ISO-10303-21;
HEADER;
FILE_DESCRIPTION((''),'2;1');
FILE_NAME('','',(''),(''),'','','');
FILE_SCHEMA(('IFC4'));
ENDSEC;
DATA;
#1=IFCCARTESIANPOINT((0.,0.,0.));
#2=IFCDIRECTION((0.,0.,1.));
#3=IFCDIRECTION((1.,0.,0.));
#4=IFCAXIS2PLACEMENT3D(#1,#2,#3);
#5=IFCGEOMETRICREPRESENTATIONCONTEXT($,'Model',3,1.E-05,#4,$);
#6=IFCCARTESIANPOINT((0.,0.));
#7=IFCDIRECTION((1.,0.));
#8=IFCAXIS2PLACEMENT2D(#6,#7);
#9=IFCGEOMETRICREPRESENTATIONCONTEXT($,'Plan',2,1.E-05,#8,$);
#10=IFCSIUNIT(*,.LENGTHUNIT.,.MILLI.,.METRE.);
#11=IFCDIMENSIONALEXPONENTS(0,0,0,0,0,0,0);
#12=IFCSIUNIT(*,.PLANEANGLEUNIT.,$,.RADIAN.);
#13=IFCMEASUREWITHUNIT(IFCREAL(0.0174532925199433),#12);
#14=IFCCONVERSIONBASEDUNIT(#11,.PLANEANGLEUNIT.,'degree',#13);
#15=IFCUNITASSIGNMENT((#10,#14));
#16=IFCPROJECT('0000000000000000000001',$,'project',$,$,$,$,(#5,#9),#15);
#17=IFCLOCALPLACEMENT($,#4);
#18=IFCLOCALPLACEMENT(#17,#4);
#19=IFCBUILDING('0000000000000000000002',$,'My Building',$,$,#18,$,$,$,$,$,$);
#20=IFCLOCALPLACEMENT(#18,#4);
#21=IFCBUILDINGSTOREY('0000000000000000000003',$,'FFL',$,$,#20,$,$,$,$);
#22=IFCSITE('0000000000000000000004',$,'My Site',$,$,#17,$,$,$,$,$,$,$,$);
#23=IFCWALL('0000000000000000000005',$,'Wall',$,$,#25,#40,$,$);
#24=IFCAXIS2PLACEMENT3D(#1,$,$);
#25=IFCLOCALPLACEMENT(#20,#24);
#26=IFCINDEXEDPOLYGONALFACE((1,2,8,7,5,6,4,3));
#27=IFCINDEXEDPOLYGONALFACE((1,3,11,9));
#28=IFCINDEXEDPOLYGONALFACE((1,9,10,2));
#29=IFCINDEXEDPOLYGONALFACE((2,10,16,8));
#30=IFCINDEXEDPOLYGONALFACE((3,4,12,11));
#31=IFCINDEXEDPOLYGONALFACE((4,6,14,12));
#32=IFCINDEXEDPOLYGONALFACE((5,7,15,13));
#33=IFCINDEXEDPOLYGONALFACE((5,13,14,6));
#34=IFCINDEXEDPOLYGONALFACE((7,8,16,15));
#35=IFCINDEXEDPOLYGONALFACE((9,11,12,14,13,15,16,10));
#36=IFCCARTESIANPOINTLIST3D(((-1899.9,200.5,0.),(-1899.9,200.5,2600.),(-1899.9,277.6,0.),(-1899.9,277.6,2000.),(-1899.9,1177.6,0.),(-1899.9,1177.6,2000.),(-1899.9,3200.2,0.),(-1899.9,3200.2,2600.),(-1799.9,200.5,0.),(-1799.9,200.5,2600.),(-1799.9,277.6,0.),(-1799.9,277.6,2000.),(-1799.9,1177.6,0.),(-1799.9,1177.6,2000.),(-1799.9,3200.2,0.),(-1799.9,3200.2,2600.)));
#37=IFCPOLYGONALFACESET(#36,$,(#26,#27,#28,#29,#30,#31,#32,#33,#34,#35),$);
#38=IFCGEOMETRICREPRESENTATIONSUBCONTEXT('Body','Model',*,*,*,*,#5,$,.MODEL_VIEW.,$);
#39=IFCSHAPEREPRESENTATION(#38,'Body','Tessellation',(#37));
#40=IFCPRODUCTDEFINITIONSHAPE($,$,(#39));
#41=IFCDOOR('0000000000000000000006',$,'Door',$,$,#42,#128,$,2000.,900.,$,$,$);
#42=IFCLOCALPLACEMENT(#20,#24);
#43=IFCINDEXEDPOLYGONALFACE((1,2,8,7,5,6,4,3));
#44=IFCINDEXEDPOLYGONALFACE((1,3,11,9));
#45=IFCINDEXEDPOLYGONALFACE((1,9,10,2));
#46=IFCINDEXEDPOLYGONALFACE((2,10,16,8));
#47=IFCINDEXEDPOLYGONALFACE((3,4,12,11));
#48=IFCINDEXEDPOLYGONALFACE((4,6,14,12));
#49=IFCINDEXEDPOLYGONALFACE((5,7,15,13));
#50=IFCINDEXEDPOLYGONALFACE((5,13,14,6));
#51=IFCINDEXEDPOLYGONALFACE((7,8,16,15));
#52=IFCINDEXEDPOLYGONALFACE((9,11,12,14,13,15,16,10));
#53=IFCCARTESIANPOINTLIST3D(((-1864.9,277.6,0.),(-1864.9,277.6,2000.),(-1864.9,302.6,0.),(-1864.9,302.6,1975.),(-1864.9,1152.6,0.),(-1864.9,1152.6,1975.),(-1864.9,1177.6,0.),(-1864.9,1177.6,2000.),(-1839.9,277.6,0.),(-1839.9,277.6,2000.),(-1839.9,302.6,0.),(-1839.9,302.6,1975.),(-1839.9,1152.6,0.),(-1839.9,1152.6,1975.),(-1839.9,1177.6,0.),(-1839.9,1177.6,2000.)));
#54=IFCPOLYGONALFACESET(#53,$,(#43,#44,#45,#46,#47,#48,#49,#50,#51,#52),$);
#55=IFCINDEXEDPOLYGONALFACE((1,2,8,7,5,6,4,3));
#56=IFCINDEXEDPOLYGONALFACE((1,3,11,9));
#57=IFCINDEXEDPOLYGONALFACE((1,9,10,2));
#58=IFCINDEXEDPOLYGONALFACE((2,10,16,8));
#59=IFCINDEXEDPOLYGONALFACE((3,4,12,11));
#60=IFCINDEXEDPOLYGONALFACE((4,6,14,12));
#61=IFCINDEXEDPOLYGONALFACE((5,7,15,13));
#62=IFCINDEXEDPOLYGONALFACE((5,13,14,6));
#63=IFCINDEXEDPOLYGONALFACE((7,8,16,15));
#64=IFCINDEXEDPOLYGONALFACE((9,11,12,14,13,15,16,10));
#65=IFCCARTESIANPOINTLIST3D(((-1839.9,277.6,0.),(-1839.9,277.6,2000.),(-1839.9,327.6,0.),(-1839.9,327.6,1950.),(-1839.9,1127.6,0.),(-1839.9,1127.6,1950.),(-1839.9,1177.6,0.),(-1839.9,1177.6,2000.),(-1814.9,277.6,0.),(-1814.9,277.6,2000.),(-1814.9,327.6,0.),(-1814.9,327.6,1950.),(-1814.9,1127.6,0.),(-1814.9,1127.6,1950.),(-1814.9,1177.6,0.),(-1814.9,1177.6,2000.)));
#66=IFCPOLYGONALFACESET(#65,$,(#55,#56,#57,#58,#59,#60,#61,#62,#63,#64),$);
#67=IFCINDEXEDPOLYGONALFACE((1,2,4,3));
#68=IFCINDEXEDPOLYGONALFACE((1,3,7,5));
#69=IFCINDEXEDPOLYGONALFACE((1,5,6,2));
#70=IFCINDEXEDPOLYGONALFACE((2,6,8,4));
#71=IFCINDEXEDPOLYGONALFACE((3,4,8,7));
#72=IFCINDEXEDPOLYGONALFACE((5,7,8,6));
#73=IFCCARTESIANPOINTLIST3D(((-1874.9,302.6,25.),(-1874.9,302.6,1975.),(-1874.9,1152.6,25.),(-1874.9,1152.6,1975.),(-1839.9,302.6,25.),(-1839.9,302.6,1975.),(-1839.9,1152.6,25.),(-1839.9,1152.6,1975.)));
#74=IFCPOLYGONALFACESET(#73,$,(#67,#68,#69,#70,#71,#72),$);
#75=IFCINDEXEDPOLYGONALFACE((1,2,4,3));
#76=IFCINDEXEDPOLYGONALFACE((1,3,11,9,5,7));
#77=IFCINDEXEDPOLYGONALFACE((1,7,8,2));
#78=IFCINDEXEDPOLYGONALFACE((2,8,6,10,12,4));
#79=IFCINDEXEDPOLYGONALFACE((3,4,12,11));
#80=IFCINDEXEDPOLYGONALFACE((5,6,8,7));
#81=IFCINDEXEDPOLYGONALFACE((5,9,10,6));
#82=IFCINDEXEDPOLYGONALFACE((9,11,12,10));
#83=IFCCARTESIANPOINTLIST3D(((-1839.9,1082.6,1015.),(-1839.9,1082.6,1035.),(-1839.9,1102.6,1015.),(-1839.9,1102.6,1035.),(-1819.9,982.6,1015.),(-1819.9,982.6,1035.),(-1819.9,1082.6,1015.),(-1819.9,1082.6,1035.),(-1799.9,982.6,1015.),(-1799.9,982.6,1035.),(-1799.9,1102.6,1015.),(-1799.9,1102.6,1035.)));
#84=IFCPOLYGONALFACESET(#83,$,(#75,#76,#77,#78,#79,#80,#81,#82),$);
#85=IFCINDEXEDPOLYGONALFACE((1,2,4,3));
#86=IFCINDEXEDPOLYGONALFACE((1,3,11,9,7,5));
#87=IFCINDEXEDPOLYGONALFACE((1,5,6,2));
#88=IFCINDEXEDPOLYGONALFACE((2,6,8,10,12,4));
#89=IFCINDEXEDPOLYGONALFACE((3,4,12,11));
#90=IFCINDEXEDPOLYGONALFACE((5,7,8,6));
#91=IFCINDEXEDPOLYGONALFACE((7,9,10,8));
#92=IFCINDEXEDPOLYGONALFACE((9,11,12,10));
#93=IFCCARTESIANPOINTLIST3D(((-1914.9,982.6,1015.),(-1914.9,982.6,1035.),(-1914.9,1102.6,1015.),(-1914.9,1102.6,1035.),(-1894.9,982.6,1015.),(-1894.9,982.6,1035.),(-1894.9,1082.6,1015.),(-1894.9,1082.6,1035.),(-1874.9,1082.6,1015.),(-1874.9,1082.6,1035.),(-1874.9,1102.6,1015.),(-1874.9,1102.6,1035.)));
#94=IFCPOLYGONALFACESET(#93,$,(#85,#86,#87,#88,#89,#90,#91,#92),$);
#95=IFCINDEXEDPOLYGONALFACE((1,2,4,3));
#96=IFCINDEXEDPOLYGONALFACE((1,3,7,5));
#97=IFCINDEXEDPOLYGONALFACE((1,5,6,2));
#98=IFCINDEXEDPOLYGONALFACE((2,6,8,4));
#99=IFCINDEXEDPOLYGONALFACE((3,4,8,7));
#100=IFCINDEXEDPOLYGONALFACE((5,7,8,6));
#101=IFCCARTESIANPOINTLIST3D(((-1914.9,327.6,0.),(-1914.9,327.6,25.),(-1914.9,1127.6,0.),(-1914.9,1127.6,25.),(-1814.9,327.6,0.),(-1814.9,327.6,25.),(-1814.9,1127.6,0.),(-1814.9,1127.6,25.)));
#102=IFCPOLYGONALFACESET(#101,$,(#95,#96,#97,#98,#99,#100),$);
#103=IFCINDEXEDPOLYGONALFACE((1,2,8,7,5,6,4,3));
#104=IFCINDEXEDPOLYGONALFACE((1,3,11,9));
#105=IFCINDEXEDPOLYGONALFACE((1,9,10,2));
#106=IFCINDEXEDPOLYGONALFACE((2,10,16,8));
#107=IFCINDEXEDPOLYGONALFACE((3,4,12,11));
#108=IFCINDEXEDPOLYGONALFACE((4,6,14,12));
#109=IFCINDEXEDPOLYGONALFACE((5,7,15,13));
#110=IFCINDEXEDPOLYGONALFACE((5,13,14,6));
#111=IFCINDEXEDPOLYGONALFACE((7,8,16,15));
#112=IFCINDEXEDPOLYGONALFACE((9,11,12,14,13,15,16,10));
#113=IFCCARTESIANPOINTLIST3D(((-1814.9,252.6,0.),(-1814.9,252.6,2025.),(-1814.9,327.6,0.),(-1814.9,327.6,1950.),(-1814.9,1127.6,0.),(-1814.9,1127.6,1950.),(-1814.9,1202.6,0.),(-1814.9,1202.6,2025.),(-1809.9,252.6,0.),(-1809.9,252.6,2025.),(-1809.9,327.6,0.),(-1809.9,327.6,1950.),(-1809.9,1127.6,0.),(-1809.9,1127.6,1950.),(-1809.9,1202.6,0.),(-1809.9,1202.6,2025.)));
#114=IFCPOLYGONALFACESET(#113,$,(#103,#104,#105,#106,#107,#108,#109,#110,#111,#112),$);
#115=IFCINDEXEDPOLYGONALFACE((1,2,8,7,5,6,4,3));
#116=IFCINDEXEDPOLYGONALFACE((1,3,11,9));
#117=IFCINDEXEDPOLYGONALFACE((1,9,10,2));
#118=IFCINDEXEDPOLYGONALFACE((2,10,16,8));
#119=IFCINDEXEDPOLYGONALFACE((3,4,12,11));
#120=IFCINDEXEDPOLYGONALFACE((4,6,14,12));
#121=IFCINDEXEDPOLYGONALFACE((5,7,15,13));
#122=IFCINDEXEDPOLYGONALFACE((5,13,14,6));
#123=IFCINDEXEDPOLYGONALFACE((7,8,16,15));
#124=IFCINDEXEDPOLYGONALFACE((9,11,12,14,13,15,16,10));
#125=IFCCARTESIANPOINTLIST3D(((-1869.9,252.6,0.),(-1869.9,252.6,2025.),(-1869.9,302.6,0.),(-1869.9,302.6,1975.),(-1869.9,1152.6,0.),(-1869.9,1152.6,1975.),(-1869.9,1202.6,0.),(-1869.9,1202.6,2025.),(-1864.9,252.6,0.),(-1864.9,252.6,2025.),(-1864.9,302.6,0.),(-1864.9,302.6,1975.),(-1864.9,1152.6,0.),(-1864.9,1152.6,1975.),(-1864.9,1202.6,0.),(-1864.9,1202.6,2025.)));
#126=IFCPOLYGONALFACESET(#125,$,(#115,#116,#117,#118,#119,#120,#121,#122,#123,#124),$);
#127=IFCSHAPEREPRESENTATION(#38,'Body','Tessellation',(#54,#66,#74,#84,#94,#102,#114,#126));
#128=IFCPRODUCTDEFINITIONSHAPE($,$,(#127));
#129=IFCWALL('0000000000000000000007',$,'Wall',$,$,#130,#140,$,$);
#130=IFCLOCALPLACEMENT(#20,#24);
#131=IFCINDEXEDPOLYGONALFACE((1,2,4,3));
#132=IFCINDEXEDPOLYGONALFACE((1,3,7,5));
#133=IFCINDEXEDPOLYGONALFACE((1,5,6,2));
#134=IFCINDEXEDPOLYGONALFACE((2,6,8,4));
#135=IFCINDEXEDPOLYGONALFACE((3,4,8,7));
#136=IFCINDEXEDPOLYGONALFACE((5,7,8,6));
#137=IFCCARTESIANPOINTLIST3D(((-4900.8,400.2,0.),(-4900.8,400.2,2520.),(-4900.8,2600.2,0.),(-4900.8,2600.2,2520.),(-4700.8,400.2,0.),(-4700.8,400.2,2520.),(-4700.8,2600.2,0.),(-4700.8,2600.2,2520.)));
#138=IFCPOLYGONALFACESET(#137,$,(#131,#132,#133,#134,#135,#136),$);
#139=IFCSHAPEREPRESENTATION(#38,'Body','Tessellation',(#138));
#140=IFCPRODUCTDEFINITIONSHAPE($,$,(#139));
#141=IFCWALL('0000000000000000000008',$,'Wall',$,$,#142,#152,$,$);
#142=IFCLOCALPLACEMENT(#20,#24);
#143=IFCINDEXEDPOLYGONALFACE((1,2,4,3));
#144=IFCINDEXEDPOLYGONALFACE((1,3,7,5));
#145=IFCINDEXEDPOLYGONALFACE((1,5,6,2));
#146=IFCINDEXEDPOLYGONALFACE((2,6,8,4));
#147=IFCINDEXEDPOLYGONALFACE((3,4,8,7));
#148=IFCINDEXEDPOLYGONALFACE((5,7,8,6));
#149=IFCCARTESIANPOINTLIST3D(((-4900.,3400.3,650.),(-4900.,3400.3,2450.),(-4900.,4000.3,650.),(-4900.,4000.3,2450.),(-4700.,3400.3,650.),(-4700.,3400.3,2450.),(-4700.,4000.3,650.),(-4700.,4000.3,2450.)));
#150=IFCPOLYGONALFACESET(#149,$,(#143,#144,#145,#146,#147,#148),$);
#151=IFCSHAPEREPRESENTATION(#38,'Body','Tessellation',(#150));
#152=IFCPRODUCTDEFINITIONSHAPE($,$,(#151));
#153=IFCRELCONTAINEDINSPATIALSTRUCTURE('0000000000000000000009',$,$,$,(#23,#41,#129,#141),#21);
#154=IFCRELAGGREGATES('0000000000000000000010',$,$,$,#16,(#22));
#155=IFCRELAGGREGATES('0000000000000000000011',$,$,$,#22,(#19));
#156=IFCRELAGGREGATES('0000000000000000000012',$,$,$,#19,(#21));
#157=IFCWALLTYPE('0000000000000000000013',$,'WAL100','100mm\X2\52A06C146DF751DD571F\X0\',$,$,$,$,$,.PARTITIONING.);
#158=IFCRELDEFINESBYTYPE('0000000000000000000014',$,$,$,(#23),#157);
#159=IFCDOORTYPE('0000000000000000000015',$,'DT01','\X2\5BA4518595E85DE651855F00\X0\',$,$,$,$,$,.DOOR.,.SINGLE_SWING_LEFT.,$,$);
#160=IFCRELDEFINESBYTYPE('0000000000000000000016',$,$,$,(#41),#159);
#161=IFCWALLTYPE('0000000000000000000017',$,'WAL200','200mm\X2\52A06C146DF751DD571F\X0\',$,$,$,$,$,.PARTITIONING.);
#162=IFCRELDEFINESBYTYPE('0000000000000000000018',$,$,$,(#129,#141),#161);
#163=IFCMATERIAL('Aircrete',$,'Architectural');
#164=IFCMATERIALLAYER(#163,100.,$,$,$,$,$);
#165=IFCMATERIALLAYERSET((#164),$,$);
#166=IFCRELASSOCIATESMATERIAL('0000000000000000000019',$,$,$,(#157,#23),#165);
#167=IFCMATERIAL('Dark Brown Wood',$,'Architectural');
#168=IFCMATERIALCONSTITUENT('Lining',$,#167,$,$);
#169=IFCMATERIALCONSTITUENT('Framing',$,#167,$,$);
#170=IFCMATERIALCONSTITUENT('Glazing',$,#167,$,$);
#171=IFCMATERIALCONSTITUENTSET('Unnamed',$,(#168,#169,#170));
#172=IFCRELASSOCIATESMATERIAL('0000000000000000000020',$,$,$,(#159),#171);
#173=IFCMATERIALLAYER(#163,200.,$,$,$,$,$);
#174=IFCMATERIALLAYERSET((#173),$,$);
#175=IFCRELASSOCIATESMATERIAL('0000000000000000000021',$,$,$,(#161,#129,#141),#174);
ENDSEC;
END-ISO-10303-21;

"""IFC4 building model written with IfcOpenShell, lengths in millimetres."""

from ifc_helpers import new_model, entity, si_unit, converted_unit, frame, origin_with_axes, origin_2d_with_axis, place, context, subcontext, project, spatial, line, indexed_curve, outline, extrude, shape, source, transform, mapped, material, layer, layer_set, layer_usage, constituent, constituent_set, type_object, type_shapes, element, fill, save


model = new_model("IFC4")

# Units and contexts
model_context = context("Model", 3, precision=1e-05, world=origin_with_axes())
plan_context = context("Plan", 2, precision=1e-05, world=origin_2d_with_axis())
body_context_1 = subcontext(model_context, "Body", "Model", "MODEL_VIEW")
body_context_2 = subcontext(plan_context, "Body", "Plan", "PLAN_VIEW")
ifc_project = project(units=[si_unit("LENGTHUNIT", "METRE", prefix="MILLI"), converted_unit("PLANEANGLEUNIT", "degree", entity("IfcReal", 0.0174532925199433), si_unit("PLANEANGLEUNIT", "RADIAN"), dimensions=[0, 0, 0, 0, 0, 0, 0])], contexts=[model_context, plan_context])

# Site, building, storey
site_placement = place(None, origin_with_axes())
site = spatial("IfcSite", under=ifc_project, at=site_placement, Name="My Site")
building_placement = place(site_placement, origin_with_axes())
building = spatial("IfcBuilding", under=site, at=building_placement, Name="My Building")
storey_placement = place(building_placement, origin_with_axes())
storey = spatial("IfcBuildingStorey", under=building, at=storey_placement, Name="FFL")

# Shared definitions
ifc_material_1 = material(Name="Aircrete", Category="Architectural")

# Wall, opening, door
ifc_layer_1 = layer(ifc_material_1, 100.0)
ifc_layer_set_1 = layer_set([ifc_layer_1])
ifc_layer_usage_1 = layer_usage(ifc_layer_set_1, "AXIS2", "POSITIVE", 0.0)
wall_type_1 = type_object("IfcWallType", Name="WAL100", Description="100mm加气混凝土", PredefinedType="PARTITIONING", material=ifc_layer_set_1)
wall_1_placement = place(storey_placement, frame((-1899.9, 3200.2, 0.0), z_axis=(0.0, 0.0, 1.0), x_axis=(0.0, -1.0, 0.0)))
wall_1 = element("IfcWall", 1, at=wall_1_placement, inside=storey, type_object=wall_type_1, material=ifc_layer_usage_1, Name="Wall", context=body_context_1, shape_type="SweptSolid", body=[
    extrude(outline(indexed_curve([(0.0, 0.0), (0.0, 100.0), (2999.7, 100.0), (2999.7, 0.0)], segments=[line(1, 2, 3, 4, 1)])), origin_with_axes(), (0.0, 0.0, 1.0), 2600.0),
])
shared_shape_1 = source(origin_with_axes(), body_context_1, "Body", "SweptSolid", [
    extrude(outline(indexed_curve([(0.0, 0.0), (900.0, 0.0), (900.0, 2000.0), (0.0, 2000.0)], segments=[line(1, 2, 3, 4, 1)])), frame((0.0, -600.0, 0.0), z_axis=(0.0, -1.0, 0.0), x_axis=(1.0, 0.0, 0.0)), (0.0, 0.0, -1.0), 1200.0),
])
opening_1_placement = place(wall_1_placement, frame((2922.6, 85.0, 0.0), z_axis=(0.0, 0.0, 1.0), x_axis=(-1.0, 0.0, 0.0)))
opening_1 = element("IfcOpeningElement", 2, at=opening_1_placement, cuts=wall_1, PredefinedType="OPENING", context=body_context_1, shape_type="MappedRepresentation", body=[
    mapped(shared_shape_1, transform((0.0, 0.0, 0.0), x_axis=(1.0, 0.0, 0.0), y_axis=(0.0, 1.0, 0.0), z_axis=(0.0, 0.0, 1.0), scale=1.0)),
])
ifc_material_2 = material(Name="Dark Brown Wood", Category="Architectural")
ifc_constituent_1 = constituent(ifc_material_2, Name="Lining")
ifc_constituent_2 = constituent(ifc_material_2, Name="Framing")
ifc_constituent_3 = constituent(ifc_material_2, Name="Glazing")
ifc_constituent_set_1 = constituent_set(constituents=[ifc_constituent_1, ifc_constituent_2, ifc_constituent_3], Name="Unnamed")
door_type = type_object("IfcDoorType", Name="DT01", Description="室内门左内开", OperationType="SINGLE_SWING_LEFT", PredefinedType="DOOR", material=ifc_constituent_set_1)
shared_shape_2 = source(origin_with_axes(), body_context_1, "Body", "SweptSolid", [
    extrude(outline(indexed_curve([(0.0, 0.0), (0.0, 2000.0), (900.0, 2000.0), (900.0, 0.0), (875.0, 0.0), (875.0, 1975.0), (25.0, 1975.0), (25.0, 0.0)], segments=[line(1, 2, 3, 4, 5, 6, 7, 8, 1)])), frame((0.0, 25.0, 0.0), z_axis=(0.0, -1.0, 0.0), x_axis=(1.0, 0.0, 0.0)), (0.0, 0.0, -1.0), 25.0),
    extrude(outline(indexed_curve([(0.0, 0.0), (0.0, 2000.0), (900.0, 2000.0), (900.0, 0.0), (850.0, 0.0), (850.0, 1950.0), (50.0, 1950.0), (50.0, 0.0)], segments=[line(1, 2, 3, 4, 5, 6, 7, 8, 1)])), frame((0.0, 0.0, 0.0), z_axis=(0.0, -1.0, 0.0), x_axis=(1.0, 0.0, 0.0)), (0.0, 0.0, -1.0), 25.0),
    extrude(outline(indexed_curve([(0.0, 0.0), (850.0, 0.0), (850.0, 35.0), (0.0, 35.0)], segments=[line(1, 2, 3, 4, 1)])), frame((25.0, 25.0, 25.0), z_axis=(0.0, 0.0, 1.0), x_axis=(1.0, 0.0, 0.0)), (0.0, 0.0, 1.0), 1950.0),
    extrude(outline(indexed_curve([(0.0, 0.0), (0.0, -40.0), (-120.0, -40.0), (-120.0, -20.0), (-20.0, -20.0), (-20.0, 0.0)], segments=[line(1, 2, 3, 4, 5, 6, 1)])), frame((825.0, 25.0, 1015.0), z_axis=(0.0, 0.0, 1.0), x_axis=(1.0, 0.0, 0.0)), (0.0, 0.0, 1.0), 20.0),
    extrude(outline(indexed_curve([(0.0, 0.0), (0.0, 40.0), (-120.0, 40.0), (-120.0, 20.0), (-20.0, 20.0), (-20.0, 0.0)], segments=[line(1, 2, 3, 4, 5, 6, 1)])), frame((825.0, 60.0, 1015.0), z_axis=(0.0, 0.0, 1.0), x_axis=(1.0, 0.0, 0.0)), (0.0, 0.0, 1.0), 20.0),
    extrude(outline(indexed_curve([(0.0, 0.0), (800.0, 0.0), (800.0, 100.0), (0.0, 100.0)], segments=[line(1, 2, 3, 4, 1)])), frame((50.0, 0.0, 0.0), z_axis=(0.0, 0.0, 1.0), x_axis=(1.0, 0.0, 0.0)), (0.0, 0.0, 1.0), 25.0),
    extrude(outline(indexed_curve([(0.0, 0.0), (0.0, 2025.0), (950.0, 2025.0), (950.0, 0.0), (875.0, 0.0), (875.0, 1950.0), (75.0, 1950.0), (75.0, 0.0)], segments=[line(1, 2, 3, 4, 5, 6, 7, 8, 1)])), frame((-25.0, -5.0, 0.0), z_axis=(0.0, -1.0, 0.0), x_axis=(1.0, 0.0, 0.0)), (0.0, 0.0, -1.0), 5.0),
    extrude(outline(indexed_curve([(0.0, 0.0), (0.0, 2025.0), (950.0, 2025.0), (950.0, 0.0), (900.0, 0.0), (900.0, 1975.0), (50.0, 1975.0), (50.0, 0.0)], segments=[line(1, 2, 3, 4, 5, 6, 7, 8, 1)])), frame((-25.0, 50.0, 0.0), z_axis=(0.0, -1.0, 0.0), x_axis=(1.0, 0.0, 0.0)), (0.0, 0.0, -1.0), 5.0),
])
shared_shape_3 = source(origin_with_axes(), body_context_2, "Body", "Curve2D", [
    entity("IfcIndexedPolyCurve", entity("IfcCartesianPointList2D", [[0.0, 0.0], [0.0, 50.0], [25.0, 50.0], [25.0, 25.0], [50.0, 25.0], [50.0, 0.0]]), [entity("IfcLineIndex", [1, 2, 3, 4, 5, 6, 1])]),
    entity("IfcIndexedPolyCurve", entity("IfcCartesianPointList2D", [[900.0, 0.0], [900.0, 50.0], [875.0, 50.0], [875.0, 25.0], [850.0, 25.0], [850.0, 0.0]]), [entity("IfcLineIndex", [1, 2, 3, 4, 5, 6, 1])]),
    entity("IfcTrimmedCurve", entity("IfcEllipse", entity("IfcAxis2Placement2D", entity("IfcCartesianPoint", [60.0, 50.0]), entity("IfcDirection", [1.0, 0.0])), 815.0, 850.0), [entity("IfcCartesianPoint", [875.0, 50.0])], [entity("IfcCartesianPoint", [60.0, 900.0])], True, "CARTESIAN"),
    entity("IfcIndexedPolyCurve", entity("IfcCartesianPointList2D", [[25.0, 50.0], [60.0, 50.0], [60.0, 900.0], [25.0, 900.0]]), [entity("IfcLineIndex", [1, 2, 3, 4, 1])]),
])
type_shapes(door_type, [shared_shape_2, shared_shape_3])
door_placement = place(opening_1_placement, frame((0.0, 0.0, 0.0), z_axis=(0.0, 0.0, 1.0), x_axis=(1.0, 0.0, 0.0)))
door = element("IfcDoor", 3, at=door_placement, inside=storey, type_object=door_type, Name="Door", OverallHeight=2000.0, OverallWidth=900.0, shapes=[
    shape(body_context_1, "Body", "MappedRepresentation", [mapped(shared_shape_2, transform((0.0, 0.0, 0.0), x_axis=(1.0, 0.0, 0.0), y_axis=(0.0, 1.0, 0.0), z_axis=(0.0, 0.0, 1.0), scale=1.0))]),
    shape(body_context_2, "Body", "MappedRepresentation", [mapped(shared_shape_3, transform((0.0, 0.0, 0.0), x_axis=(1.0, 0.0, 0.0), y_axis=(0.0, 1.0, 0.0), z_axis=(0.0, 0.0, 1.0), scale=1.0))]),
])
fill(opening_1, door)

# Walls
ifc_layer_2 = layer(ifc_material_1, 200.0)
ifc_layer_set_2 = layer_set([ifc_layer_2])
ifc_layer_usage_2 = layer_usage(ifc_layer_set_2, "AXIS2", "NEGATIVE", 0.0)
wall_type_2 = type_object("IfcWallType", Name="WAL200", Description="200mm加气混凝土", PredefinedType="PARTITIONING", material=ifc_layer_set_2)
wall_2_placement = place(storey_placement, frame((-4900.8, 400.2, 0.0), z_axis=(0.0, 0.0, 1.0), x_axis=(0.0, 1.0, 0.0)))
element("IfcWall", 4, at=wall_2_placement, inside=storey, type_object=wall_type_2, material=ifc_layer_usage_2, Name="Wall", context=body_context_1, shape_type="SweptSolid", body=[
    extrude(outline(indexed_curve([(0.0, -200.0), (0.0, 0.0), (2200.0, 0.0), (2200.0, -200.0)], segments=[line(1, 2, 3, 4, 1)])), origin_with_axes(), (0.0, 0.0, 1.0), 2520.0),
])
ifc_layer_usage_3 = layer_usage(ifc_layer_set_2, "AXIS2", "NEGATIVE", 0.0)
wall_3_placement = place(storey_placement, frame((-4900.0, 3400.3, 650.0), z_axis=(0.0, 0.0, 1.0), x_axis=(0.0, 1.0, 0.0)))
element("IfcWall", 5, at=wall_3_placement, inside=storey, type_object=wall_type_2, material=ifc_layer_usage_3, Name="Wall", context=body_context_1, shape_type="SweptSolid", body=[
    extrude(outline(indexed_curve([(0.0, -200.0), (0.0, 0.0), (600.0, 0.0), (600.0, -200.0)], segments=[line(1, 2, 3, 4, 1)])), origin_with_axes(), (0.0, 0.0, 1.0), 1800.0),
])

save(model, "model.ifc")
